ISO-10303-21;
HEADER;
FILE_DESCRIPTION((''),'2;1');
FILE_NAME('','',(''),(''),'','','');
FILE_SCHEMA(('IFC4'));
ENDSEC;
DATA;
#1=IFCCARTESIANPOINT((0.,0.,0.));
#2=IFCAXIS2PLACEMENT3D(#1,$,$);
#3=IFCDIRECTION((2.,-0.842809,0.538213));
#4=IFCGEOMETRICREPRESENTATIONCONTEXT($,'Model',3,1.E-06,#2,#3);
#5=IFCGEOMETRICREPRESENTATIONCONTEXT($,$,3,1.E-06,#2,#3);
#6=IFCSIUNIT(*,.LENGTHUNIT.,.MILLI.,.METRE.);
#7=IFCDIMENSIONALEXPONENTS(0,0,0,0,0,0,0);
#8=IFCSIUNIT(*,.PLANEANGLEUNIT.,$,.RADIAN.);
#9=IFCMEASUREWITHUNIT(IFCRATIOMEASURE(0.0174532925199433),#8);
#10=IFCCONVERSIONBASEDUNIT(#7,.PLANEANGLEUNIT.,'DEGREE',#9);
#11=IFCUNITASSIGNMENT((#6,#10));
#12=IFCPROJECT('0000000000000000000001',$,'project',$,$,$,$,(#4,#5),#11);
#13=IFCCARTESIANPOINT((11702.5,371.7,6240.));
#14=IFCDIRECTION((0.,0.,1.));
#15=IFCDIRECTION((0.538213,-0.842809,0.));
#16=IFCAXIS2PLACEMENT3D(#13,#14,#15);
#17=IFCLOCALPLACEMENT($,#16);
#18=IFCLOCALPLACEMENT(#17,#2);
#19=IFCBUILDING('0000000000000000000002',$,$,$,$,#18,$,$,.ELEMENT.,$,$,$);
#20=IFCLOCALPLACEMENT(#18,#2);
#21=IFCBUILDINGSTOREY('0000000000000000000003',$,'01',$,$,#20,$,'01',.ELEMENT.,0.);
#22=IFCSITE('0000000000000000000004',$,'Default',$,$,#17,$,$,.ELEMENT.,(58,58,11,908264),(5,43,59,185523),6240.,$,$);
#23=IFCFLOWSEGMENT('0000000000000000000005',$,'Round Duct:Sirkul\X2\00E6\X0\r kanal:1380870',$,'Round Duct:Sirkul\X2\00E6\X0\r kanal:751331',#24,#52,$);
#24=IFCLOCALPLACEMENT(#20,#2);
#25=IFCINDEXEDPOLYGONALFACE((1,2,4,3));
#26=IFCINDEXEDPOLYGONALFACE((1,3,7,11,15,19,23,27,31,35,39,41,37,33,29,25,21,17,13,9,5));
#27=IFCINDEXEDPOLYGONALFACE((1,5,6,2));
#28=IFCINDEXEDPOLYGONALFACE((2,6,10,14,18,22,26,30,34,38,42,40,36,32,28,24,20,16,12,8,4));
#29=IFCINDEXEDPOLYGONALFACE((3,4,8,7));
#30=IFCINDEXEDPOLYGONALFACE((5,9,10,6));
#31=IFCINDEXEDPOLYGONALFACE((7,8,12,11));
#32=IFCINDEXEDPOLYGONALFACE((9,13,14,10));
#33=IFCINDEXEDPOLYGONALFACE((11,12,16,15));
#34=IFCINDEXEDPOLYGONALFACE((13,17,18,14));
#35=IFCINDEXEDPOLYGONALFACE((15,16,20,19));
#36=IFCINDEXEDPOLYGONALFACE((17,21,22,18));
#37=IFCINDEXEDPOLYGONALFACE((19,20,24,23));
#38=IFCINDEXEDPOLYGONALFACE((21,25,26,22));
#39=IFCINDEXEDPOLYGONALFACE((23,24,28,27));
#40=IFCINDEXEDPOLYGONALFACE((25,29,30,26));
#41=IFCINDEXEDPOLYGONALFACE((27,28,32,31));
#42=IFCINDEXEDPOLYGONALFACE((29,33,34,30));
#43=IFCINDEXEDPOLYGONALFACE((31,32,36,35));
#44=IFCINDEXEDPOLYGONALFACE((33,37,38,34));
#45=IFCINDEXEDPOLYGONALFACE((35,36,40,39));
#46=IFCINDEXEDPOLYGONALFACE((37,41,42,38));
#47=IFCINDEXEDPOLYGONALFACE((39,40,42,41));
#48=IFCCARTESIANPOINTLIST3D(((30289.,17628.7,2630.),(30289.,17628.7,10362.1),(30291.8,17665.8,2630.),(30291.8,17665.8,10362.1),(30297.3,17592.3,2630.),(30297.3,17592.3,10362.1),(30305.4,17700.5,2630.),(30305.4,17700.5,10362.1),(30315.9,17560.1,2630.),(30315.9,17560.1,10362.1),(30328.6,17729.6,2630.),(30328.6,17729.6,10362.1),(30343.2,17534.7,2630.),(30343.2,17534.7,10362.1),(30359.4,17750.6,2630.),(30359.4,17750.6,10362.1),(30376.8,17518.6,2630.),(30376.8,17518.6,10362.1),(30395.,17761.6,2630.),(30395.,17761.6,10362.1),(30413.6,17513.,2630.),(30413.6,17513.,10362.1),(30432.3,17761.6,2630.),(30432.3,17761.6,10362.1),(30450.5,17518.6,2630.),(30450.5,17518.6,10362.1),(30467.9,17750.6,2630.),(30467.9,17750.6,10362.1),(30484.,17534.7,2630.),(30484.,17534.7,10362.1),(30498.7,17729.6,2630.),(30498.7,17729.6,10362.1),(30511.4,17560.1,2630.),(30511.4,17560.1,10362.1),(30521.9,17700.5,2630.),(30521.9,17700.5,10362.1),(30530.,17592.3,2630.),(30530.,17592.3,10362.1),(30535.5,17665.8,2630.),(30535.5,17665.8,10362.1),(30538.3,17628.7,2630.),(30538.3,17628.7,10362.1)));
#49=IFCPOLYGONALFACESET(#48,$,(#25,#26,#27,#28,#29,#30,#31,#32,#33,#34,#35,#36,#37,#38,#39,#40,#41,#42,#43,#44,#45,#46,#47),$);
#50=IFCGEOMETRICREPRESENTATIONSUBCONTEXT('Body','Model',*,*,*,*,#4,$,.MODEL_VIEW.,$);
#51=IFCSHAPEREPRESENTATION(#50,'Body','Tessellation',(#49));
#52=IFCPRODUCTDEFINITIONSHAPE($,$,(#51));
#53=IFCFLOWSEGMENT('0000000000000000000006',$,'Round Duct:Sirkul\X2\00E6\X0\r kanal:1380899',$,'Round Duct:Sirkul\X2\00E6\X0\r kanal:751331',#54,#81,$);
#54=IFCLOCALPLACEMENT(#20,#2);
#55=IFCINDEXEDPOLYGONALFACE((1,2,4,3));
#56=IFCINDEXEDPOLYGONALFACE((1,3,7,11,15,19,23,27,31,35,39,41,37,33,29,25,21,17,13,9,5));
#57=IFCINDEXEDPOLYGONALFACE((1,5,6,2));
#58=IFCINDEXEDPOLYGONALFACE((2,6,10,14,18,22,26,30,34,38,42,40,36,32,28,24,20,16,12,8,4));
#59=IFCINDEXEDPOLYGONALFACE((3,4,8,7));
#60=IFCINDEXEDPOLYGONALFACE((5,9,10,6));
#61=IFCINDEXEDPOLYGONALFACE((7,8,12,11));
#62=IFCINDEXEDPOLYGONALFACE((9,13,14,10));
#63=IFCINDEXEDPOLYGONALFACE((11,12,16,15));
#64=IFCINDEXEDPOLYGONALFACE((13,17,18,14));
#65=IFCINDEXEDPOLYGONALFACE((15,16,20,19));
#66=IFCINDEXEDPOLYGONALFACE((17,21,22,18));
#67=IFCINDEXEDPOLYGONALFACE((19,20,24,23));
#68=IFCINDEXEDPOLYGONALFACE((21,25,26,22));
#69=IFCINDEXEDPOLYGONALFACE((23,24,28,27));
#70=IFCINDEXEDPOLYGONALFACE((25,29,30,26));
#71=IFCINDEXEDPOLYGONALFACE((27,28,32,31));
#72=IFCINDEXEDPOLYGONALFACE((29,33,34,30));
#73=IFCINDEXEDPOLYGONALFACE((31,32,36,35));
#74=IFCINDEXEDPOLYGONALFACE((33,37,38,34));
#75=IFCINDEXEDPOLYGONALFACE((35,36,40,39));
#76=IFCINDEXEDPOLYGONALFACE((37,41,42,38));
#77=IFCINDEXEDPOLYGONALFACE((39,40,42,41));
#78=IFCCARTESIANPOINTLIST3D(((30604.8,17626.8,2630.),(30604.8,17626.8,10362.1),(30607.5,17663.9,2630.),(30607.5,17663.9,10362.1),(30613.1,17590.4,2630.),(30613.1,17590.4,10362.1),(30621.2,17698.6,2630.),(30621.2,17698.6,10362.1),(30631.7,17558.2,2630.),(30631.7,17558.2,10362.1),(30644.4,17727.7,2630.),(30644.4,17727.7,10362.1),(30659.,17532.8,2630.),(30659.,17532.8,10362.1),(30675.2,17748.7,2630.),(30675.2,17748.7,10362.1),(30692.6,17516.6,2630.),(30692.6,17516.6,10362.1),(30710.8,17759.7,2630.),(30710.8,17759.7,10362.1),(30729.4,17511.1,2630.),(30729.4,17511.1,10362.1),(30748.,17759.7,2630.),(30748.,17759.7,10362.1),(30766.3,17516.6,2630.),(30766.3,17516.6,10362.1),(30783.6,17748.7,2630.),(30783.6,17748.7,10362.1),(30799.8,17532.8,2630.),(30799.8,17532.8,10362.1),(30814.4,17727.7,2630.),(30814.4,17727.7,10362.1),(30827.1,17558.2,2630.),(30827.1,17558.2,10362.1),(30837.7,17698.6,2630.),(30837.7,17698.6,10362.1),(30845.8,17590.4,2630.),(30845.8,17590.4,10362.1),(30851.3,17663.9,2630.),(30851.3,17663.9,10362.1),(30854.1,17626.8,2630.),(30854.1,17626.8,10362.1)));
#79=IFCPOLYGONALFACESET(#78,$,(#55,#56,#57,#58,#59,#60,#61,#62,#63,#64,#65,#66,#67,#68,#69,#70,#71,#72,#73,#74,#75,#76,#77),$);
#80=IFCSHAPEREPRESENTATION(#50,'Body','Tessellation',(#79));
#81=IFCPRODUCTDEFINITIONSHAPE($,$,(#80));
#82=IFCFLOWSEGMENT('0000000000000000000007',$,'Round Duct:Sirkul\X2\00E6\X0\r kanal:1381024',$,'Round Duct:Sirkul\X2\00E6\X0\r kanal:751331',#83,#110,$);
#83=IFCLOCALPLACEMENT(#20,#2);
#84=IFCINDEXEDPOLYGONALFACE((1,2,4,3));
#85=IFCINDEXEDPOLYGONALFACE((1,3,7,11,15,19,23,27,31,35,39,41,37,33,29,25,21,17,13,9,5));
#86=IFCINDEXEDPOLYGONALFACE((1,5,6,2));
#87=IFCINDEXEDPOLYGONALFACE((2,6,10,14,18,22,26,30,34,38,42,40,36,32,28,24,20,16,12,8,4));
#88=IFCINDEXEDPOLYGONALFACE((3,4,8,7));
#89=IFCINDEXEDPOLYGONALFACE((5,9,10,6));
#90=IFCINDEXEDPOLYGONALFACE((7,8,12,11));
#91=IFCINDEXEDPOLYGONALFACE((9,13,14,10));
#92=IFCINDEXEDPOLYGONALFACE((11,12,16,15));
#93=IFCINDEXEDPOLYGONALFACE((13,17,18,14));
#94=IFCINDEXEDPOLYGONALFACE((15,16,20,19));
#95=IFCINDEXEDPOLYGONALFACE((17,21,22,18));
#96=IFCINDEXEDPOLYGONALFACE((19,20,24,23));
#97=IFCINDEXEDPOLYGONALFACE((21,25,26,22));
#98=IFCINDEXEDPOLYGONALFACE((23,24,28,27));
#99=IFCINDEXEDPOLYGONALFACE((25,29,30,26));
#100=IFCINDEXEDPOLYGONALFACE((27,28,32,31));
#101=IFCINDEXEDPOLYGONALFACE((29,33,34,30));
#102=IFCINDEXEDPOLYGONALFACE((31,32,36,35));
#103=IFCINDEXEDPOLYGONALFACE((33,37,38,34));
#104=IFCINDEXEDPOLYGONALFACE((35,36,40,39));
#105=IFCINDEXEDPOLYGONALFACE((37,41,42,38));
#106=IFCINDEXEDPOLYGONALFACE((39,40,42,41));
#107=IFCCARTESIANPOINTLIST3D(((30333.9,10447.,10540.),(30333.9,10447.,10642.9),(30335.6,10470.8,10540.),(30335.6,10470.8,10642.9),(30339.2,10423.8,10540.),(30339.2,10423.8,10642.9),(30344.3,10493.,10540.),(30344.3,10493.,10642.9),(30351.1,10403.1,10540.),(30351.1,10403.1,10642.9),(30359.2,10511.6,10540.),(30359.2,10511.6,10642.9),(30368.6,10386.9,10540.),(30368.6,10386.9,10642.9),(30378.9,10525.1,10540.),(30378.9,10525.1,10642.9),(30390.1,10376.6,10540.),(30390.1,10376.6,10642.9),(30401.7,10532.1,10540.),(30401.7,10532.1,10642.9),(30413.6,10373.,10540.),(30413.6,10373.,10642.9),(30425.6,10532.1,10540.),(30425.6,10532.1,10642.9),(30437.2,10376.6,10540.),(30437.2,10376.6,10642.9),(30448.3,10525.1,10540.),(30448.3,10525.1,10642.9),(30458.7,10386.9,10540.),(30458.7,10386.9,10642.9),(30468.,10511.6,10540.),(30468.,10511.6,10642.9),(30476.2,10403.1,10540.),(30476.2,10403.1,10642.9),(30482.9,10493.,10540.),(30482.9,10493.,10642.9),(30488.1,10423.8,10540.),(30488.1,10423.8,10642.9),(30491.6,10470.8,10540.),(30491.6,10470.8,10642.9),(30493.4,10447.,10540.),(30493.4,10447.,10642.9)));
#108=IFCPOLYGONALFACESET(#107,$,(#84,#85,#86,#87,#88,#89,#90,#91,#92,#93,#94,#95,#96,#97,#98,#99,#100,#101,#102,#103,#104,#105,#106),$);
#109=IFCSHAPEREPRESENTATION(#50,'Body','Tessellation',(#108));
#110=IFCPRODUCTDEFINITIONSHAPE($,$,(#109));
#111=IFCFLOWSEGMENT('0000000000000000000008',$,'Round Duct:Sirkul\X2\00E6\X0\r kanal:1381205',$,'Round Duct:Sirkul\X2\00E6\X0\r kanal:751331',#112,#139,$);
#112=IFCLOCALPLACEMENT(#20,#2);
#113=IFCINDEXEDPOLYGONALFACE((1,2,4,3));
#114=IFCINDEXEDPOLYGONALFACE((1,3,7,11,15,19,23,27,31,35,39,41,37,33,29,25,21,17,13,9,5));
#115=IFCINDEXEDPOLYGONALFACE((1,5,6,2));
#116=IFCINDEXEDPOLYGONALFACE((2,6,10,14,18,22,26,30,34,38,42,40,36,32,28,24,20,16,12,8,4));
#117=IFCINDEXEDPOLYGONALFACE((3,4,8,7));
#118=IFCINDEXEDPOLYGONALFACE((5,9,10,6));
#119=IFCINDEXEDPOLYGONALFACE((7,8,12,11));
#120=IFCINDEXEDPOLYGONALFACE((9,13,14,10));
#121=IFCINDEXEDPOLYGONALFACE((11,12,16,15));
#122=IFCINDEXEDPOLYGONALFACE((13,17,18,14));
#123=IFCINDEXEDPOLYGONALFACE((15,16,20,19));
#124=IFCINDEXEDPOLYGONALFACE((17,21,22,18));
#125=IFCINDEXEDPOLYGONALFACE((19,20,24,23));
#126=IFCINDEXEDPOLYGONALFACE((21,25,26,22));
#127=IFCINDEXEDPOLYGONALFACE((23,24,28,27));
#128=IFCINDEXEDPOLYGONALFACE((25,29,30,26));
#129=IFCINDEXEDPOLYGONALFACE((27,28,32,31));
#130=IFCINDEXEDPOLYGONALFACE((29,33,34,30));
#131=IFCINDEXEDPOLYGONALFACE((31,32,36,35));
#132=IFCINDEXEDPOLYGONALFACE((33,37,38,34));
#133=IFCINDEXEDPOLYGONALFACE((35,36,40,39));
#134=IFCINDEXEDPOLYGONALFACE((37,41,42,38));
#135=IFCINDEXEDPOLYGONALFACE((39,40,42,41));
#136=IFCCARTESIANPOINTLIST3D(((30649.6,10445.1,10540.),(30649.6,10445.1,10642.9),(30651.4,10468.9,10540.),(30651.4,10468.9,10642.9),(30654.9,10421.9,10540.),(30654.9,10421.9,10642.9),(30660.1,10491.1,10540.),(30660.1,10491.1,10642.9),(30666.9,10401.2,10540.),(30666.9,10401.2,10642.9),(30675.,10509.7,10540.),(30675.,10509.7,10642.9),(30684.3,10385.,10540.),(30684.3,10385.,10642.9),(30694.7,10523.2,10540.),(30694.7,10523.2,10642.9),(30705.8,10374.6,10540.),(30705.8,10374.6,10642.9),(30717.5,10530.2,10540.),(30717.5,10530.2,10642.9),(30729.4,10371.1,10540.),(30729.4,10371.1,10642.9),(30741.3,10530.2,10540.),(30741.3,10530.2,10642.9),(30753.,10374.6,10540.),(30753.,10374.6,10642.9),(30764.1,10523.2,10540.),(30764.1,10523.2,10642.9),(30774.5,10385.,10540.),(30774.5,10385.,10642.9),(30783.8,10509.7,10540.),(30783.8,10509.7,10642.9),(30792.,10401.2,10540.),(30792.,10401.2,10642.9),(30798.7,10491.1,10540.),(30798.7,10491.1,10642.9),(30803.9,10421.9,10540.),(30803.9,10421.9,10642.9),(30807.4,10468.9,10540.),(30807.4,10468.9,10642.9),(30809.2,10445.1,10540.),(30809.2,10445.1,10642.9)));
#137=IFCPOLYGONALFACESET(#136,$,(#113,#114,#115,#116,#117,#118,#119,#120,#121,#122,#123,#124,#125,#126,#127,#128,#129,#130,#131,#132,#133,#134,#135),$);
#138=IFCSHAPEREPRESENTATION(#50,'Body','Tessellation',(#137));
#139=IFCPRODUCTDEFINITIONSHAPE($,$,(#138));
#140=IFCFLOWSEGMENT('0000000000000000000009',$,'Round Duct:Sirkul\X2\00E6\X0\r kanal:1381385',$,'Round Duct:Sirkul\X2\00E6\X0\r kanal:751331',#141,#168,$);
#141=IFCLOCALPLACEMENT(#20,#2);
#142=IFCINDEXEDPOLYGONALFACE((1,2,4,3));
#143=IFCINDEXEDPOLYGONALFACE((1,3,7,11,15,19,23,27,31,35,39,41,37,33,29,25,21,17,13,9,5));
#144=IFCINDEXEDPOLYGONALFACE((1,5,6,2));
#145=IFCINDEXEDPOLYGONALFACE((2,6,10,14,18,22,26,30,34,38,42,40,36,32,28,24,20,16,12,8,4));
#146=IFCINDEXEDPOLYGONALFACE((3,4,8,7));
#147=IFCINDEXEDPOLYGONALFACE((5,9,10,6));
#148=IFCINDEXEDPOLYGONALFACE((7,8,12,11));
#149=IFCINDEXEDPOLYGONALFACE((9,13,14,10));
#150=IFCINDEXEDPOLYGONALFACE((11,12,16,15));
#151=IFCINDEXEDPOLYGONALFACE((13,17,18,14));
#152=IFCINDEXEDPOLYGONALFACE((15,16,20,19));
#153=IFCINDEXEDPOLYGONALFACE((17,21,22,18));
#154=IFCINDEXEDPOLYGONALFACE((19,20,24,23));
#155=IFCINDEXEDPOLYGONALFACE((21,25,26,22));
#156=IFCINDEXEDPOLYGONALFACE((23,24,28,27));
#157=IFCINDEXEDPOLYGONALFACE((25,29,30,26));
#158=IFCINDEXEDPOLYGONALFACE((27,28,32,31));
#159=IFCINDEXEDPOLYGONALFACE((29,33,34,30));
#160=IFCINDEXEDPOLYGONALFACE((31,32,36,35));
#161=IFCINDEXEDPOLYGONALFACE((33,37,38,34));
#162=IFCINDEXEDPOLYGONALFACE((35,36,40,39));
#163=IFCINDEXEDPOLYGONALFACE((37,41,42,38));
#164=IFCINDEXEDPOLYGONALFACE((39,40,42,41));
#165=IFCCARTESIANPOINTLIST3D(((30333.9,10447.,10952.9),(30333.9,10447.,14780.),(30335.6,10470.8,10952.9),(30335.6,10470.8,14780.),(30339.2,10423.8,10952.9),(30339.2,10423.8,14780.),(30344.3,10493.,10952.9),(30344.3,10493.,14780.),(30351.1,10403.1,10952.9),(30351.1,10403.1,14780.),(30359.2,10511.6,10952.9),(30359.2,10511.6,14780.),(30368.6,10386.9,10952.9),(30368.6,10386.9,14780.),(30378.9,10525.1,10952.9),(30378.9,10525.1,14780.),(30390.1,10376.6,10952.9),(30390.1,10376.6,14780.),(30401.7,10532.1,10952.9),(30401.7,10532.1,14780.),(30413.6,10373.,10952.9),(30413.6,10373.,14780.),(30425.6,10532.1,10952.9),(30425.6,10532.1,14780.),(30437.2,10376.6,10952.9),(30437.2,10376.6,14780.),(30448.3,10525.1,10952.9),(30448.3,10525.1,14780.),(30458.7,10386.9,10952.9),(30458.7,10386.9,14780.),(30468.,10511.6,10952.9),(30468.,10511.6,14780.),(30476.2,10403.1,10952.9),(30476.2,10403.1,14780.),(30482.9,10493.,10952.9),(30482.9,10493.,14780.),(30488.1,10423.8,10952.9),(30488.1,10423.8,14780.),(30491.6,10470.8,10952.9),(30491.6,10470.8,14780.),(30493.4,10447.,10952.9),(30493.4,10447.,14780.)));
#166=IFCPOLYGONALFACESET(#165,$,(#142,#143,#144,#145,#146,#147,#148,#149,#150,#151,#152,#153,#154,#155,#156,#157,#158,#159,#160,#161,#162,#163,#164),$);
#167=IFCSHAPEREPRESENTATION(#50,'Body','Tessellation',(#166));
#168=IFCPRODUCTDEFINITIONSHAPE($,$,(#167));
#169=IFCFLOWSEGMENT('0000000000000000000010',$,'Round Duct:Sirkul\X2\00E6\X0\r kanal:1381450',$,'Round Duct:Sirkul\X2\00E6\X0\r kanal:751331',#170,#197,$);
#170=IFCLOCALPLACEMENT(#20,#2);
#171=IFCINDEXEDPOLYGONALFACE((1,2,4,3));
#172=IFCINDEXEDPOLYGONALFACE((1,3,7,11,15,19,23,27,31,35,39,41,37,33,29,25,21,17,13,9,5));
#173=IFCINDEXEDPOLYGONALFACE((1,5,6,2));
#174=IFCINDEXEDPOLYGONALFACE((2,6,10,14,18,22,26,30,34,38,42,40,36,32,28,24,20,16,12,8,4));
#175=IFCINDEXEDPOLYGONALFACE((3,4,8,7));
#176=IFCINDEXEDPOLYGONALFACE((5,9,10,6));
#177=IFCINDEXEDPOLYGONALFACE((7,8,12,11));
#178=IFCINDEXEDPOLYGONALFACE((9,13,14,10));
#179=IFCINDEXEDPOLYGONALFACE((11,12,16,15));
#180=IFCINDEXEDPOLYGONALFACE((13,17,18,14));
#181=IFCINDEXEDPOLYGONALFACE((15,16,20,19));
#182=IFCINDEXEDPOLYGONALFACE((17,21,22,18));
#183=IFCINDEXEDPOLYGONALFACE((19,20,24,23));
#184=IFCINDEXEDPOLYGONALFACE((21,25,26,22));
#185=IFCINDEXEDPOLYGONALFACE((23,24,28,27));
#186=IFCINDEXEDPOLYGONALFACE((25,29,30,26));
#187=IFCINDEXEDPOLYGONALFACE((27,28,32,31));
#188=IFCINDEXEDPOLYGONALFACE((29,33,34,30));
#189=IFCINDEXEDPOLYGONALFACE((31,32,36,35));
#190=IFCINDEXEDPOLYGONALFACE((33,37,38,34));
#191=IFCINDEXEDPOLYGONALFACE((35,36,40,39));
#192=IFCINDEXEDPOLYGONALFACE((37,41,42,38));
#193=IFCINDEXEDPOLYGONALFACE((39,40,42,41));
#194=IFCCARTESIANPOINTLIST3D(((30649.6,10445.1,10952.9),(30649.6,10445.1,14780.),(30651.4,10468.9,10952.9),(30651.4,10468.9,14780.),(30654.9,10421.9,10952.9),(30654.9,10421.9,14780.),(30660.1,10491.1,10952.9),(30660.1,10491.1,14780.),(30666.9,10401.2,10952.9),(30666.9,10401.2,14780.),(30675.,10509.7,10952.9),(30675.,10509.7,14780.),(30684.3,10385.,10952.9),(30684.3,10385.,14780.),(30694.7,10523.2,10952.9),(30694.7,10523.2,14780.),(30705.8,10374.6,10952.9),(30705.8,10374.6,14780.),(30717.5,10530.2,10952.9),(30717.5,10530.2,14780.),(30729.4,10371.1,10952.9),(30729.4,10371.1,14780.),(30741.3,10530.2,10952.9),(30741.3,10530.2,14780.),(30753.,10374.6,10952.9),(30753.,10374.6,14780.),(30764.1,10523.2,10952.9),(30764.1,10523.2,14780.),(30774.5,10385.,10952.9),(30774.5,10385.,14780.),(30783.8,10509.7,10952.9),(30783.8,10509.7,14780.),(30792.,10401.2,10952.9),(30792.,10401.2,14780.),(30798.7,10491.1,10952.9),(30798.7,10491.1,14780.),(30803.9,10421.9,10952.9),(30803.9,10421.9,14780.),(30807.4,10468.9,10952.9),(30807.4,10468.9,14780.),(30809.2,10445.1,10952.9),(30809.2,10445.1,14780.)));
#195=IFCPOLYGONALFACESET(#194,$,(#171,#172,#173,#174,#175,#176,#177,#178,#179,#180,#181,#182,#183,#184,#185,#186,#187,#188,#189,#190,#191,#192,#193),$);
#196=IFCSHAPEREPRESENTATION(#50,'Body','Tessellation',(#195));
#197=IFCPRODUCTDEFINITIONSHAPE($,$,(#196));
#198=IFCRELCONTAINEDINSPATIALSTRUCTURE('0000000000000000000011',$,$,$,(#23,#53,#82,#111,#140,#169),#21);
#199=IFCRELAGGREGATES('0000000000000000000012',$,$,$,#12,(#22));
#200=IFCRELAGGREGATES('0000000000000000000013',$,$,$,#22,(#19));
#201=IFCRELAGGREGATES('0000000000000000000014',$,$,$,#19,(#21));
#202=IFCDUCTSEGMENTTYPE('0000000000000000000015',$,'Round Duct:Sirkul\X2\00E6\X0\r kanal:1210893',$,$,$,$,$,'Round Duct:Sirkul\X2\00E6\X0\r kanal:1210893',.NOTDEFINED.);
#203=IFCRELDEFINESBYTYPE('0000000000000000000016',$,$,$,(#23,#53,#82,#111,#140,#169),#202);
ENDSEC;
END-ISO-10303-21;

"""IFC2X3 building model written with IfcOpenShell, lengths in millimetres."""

from ifc_helpers import new_model, entity, si_unit, converted_unit, direction, frame, frame_2d, origin, origin_2d_with_axis, place, context, subcontext, project, spatial, circle, extrude, type_object, element, save


model = new_model("IFC2X3")

# Units and contexts
model_context = context("Model", 3, precision=1e-06, world=origin(), true_north=direction((2.0, -0.842809, 0.538213)))
context_of_model = context(None, 3, precision=1e-06, world=origin(), true_north=direction((2.0, -0.842809, 0.538213)))
body_context = subcontext(model_context, "Body", "Model", "MODEL_VIEW")
ifc_project = project(units=[si_unit("LENGTHUNIT", "METRE", prefix="MILLI"), converted_unit("PLANEANGLEUNIT", "DEGREE", entity("IfcRatioMeasure", 0.0174532925199433), si_unit("PLANEANGLEUNIT", "RADIAN"), dimensions=[0, 0, 0, 0, 0, 0, 0])], contexts=[model_context, context_of_model])

# Site, building, storey
site_placement = place(None, frame((11702.5, 371.7, 6240.0), z_axis=(0.0, 0.0, 1.0), x_axis=(0.538213, -0.842809, 0.0)))
site = spatial("IfcSite", under=ifc_project, at=site_placement, Name="Default", CompositionType="ELEMENT", RefLatitude=(58, 58, 11, 908264), RefLongitude=(5, 43, 59, 185523), RefElevation=6240.0)
building_placement = place(site_placement, origin())
building = spatial("IfcBuilding", under=site, at=building_placement, CompositionType="ELEMENT")
storey_placement = place(building_placement, origin())
storey = spatial("IfcBuildingStorey", under=building, at=storey_placement, Name="01", LongName="01", CompositionType="ELEMENT", Elevation=0.0)

# Flow segments
duct_segment_type_1 = type_object("IfcDuctSegmentType", Name="Round Duct:Sirkulær kanal:1210893", ElementType="Round Duct:Sirkulær kanal:1210893", PredefinedType="NOTDEFINED")
flow_segment_1_placement = place(storey_placement, origin())
element("IfcFlowSegment", 1, at=flow_segment_1_placement, inside=storey, type_object=duct_segment_type_1, Name="Round Duct:Sirkulær kanal:1380870", ObjectType="Round Duct:Sirkulær kanal:751331", context=body_context, shape_type="SweptSolid", body=[
    extrude(circle(Radius=125.0, at=frame_2d((0.0, 0.0), x_axis=(1.0, 0.0))), frame((30413.6, 17638.0, 2630.0), z_axis=(0.0, 0.0, 1.0), x_axis=(0.0, -1.0, 0.0)), (0.0, 0.0, 1.0), 7732.1),
])
flow_segment_2_placement = place(storey_placement, origin())
element("IfcFlowSegment", 2, at=flow_segment_2_placement, inside=storey, type_object=duct_segment_type_1, Name="Round Duct:Sirkulær kanal:1380899", ObjectType="Round Duct:Sirkulær kanal:751331", context=body_context, shape_type="SweptSolid", body=[
    extrude(circle(Radius=125.0, at=frame_2d((0.0, 0.0), x_axis=(1.0, 0.0))), frame((30729.4, 17636.1, 2630.0), z_axis=(0.0, 0.0, 1.0), x_axis=(0.0, -1.0, 0.0)), (0.0, 0.0, 1.0), 7732.1),
])
flow_segment_3_placement = place(storey_placement, origin())
element("IfcFlowSegment", 3, at=flow_segment_3_placement, inside=storey, type_object=duct_segment_type_1, Name="Round Duct:Sirkulær kanal:1381024", ObjectType="Round Duct:Sirkulær kanal:751331", context=body_context, shape_type="SweptSolid", body=[
    extrude(circle(Radius=80.0, at=origin_2d_with_axis()), frame((30413.6, 10453.0, 10540.0), z_axis=(0.0, 0.0, 1.0), x_axis=(0.0, -1.0, 0.0)), (0.0, 0.0, 1.0), 102.9),
])
flow_segment_4_placement = place(storey_placement, origin())
element("IfcFlowSegment", 4, at=flow_segment_4_placement, inside=storey, type_object=duct_segment_type_1, Name="Round Duct:Sirkulær kanal:1381205", ObjectType="Round Duct:Sirkulær kanal:751331", context=body_context, shape_type="SweptSolid", body=[
    extrude(circle(Radius=80.0, at=origin_2d_with_axis()), frame((30729.4, 10451.1, 10540.0), z_axis=(0.0, 0.0, 1.0), x_axis=(0.0, -1.0, 0.0)), (0.0, 0.0, 1.0), 102.9),
])
flow_segment_5_placement = place(storey_placement, origin())
element("IfcFlowSegment", 5, at=flow_segment_5_placement, inside=storey, type_object=duct_segment_type_1, Name="Round Duct:Sirkulær kanal:1381385", ObjectType="Round Duct:Sirkulær kanal:751331", context=body_context, shape_type="SweptSolid", body=[
    extrude(circle(Radius=80.0, at=frame_2d((0.0, 0.0), x_axis=(1.0, 0.0))), frame((30413.6, 10453.0, 10952.9), z_axis=(0.0, 0.0, 1.0), x_axis=(0.0, -1.0, 0.0)), (0.0, 0.0, 1.0), 3827.1),
])
flow_segment_6_placement = place(storey_placement, origin())
element("IfcFlowSegment", 6, at=flow_segment_6_placement, inside=storey, type_object=duct_segment_type_1, Name="Round Duct:Sirkulær kanal:1381450", ObjectType="Round Duct:Sirkulær kanal:751331", context=body_context, shape_type="SweptSolid", body=[
    extrude(circle(Radius=80.0, at=frame_2d((0.0, 0.0), x_axis=(1.0, 0.0))), frame((30729.4, 10451.1, 10952.9), z_axis=(0.0, 0.0, 1.0), x_axis=(0.0, -1.0, 0.0)), (0.0, 0.0, 1.0), 3827.1),
])

save(model, "model.ifc")
